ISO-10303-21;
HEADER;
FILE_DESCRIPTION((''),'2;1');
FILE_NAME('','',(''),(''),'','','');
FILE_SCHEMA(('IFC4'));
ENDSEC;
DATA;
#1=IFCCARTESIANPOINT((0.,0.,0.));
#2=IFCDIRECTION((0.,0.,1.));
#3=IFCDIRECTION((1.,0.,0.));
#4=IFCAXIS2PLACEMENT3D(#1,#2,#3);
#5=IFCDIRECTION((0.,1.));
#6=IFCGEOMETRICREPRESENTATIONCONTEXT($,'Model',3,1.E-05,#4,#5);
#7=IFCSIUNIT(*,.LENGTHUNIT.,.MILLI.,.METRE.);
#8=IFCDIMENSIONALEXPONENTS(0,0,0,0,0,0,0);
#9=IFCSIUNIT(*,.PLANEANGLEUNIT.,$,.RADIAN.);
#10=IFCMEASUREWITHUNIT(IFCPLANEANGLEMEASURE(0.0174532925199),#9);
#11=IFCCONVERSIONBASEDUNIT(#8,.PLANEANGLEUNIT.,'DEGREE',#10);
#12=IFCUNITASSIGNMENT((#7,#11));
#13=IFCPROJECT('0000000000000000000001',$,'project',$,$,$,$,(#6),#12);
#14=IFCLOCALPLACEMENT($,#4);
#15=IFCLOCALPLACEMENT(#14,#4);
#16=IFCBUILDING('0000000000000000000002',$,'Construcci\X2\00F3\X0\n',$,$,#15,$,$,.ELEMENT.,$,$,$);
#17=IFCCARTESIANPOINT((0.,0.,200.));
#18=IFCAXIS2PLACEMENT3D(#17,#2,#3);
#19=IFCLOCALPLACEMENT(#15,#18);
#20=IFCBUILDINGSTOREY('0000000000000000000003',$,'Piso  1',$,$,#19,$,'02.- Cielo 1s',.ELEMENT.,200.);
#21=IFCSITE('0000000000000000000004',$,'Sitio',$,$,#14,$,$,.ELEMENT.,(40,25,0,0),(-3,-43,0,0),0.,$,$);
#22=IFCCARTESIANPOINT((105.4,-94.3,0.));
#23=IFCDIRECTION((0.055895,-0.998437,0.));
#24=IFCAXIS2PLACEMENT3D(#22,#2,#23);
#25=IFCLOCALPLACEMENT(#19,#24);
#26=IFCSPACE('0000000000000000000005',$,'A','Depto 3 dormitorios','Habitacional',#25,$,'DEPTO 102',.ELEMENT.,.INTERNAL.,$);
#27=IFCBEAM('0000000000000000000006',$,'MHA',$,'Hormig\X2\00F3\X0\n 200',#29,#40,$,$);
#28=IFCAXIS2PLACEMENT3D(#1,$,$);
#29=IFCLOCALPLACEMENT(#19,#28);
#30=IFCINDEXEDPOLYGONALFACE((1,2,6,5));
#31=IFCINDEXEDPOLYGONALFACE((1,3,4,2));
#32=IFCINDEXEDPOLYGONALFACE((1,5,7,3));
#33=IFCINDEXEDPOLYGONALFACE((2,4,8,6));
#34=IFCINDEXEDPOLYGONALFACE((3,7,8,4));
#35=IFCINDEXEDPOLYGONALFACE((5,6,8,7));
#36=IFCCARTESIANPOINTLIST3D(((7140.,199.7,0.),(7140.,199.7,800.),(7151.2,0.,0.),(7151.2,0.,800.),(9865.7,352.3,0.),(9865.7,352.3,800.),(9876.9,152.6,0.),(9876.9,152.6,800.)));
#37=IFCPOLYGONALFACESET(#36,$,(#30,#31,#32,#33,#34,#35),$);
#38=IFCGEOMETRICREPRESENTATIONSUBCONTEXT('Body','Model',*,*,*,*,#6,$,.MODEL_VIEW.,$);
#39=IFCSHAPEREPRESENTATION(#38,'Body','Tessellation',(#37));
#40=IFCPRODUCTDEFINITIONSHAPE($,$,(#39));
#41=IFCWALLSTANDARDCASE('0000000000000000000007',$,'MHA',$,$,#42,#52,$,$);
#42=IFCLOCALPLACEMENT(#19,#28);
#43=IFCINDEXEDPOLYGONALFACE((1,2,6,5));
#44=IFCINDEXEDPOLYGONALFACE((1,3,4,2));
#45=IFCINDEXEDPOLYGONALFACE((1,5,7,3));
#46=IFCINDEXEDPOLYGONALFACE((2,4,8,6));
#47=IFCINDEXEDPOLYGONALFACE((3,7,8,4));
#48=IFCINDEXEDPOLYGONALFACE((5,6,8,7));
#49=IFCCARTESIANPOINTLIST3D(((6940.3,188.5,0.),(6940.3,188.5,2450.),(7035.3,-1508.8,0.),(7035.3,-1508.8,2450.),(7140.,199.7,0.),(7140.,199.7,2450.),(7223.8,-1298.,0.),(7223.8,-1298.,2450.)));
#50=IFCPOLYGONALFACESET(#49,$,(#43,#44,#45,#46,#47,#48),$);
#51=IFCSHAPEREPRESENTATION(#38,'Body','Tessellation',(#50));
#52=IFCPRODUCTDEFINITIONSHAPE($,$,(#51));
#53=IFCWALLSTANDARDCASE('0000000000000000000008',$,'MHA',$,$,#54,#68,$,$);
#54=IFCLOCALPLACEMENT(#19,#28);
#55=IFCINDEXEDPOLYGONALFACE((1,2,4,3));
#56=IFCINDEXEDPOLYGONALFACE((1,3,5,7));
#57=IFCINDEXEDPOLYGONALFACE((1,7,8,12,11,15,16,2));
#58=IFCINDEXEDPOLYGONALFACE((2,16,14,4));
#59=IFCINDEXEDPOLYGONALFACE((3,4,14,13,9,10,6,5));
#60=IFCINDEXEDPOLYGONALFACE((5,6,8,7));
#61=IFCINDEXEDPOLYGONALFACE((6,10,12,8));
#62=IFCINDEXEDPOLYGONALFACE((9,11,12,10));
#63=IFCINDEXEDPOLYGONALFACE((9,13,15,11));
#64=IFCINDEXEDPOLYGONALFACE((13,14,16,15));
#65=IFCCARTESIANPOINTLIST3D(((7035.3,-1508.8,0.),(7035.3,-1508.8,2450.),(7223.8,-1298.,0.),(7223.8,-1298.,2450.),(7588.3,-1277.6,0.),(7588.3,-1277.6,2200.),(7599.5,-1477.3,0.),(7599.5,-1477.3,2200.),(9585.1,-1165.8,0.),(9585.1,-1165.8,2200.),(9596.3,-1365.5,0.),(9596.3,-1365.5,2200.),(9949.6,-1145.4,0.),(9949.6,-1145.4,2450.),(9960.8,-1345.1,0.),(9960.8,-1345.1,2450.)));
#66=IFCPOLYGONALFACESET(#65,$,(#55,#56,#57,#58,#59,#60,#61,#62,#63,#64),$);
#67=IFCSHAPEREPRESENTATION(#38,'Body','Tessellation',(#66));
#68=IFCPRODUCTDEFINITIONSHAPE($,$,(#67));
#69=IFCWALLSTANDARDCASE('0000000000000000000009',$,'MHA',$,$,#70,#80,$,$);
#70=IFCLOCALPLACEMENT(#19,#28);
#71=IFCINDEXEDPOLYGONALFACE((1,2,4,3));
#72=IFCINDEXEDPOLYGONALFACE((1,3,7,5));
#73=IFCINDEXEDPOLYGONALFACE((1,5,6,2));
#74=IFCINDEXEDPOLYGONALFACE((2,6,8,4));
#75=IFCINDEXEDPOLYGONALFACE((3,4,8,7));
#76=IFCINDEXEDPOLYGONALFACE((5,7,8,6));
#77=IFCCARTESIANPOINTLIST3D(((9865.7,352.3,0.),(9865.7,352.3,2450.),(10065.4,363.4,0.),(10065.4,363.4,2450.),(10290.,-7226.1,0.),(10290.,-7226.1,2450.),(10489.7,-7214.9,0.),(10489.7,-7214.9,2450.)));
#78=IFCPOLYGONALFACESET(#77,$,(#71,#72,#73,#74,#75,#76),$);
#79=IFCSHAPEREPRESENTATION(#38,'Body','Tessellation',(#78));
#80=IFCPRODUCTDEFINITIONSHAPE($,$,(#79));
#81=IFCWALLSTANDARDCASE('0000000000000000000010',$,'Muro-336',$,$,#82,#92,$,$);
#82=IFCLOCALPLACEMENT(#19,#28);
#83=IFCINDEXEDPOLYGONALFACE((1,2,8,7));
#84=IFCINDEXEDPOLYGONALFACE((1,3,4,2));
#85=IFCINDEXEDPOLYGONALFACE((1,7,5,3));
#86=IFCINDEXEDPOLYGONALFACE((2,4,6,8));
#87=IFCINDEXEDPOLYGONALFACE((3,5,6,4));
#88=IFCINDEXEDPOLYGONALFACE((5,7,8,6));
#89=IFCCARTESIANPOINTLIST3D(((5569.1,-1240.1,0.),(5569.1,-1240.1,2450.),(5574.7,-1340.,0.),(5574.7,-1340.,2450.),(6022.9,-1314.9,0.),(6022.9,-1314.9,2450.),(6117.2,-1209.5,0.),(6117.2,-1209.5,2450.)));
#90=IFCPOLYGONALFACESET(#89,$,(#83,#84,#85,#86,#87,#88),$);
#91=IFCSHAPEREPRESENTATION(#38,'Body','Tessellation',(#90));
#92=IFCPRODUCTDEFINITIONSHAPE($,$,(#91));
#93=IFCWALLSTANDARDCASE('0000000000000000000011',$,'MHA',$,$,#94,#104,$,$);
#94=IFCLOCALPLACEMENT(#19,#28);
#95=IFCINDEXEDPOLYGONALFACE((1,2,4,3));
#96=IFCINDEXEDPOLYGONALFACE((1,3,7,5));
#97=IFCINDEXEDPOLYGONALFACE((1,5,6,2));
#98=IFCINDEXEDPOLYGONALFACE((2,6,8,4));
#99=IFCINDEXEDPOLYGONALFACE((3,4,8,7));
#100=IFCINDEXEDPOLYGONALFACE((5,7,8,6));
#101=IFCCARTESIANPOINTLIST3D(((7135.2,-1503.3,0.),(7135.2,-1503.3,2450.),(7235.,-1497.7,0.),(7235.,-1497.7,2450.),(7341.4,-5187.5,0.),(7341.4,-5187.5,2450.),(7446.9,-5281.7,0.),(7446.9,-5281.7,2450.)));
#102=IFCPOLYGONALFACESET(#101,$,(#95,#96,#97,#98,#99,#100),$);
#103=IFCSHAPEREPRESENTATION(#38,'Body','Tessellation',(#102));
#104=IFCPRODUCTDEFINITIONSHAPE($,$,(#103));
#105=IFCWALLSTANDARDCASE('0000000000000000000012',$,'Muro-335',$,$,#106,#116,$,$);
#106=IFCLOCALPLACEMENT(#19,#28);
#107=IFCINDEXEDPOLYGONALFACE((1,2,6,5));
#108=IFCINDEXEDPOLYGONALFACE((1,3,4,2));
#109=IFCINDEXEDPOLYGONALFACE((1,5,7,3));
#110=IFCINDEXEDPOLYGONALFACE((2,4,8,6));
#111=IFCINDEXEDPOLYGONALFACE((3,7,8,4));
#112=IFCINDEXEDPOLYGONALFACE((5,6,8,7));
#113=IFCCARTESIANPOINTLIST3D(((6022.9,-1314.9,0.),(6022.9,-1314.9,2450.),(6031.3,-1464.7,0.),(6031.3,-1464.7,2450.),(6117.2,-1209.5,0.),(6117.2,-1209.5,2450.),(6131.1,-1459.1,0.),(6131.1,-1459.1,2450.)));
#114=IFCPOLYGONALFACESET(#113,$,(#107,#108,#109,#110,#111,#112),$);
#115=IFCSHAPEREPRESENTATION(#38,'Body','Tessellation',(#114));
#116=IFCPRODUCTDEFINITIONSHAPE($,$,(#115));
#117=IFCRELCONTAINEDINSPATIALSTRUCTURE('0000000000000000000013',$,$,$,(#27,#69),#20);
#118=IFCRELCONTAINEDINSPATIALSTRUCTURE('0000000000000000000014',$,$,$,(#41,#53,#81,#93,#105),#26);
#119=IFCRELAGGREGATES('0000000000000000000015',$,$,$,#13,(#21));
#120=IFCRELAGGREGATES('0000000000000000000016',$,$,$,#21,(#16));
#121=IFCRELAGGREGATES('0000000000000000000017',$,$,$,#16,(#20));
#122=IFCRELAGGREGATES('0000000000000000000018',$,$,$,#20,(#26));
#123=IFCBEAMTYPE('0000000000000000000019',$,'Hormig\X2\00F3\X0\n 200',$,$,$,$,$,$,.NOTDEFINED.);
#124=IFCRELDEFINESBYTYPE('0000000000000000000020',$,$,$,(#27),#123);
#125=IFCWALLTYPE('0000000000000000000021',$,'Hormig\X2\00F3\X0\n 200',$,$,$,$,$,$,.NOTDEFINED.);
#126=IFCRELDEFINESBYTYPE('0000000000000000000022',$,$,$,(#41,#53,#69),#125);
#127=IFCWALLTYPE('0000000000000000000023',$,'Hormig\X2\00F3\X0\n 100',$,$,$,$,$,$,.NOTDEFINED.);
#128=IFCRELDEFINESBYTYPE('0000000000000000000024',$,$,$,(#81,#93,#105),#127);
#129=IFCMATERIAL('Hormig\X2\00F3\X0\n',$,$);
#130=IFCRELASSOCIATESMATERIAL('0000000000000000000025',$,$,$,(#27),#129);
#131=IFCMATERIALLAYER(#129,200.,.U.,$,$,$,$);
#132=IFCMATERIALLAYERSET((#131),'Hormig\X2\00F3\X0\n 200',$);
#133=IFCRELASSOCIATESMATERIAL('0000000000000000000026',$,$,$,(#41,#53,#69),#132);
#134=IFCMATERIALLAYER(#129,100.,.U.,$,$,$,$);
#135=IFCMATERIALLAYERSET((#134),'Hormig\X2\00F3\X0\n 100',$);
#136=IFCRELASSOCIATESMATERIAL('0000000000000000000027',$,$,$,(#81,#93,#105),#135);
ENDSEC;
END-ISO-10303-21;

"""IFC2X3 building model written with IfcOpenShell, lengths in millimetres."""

from ifc_helpers import new_model, entity, si_unit, converted_unit, direction, frame, origin_with_axes, origin_2d_with_axis, place, context, subcontext, project, spatial, polyline, rectangle, outline, extrude, material, layer, layer_set, layer_usage, type_object, element, save


model = new_model("IFC2X3")

# Units and contexts
model_context = context("Model", 3, precision=1e-05, world=origin_with_axes(), true_north=direction((0.0, 1.0)))
body_context = subcontext(model_context, "Body", "Model", "MODEL_VIEW")
ifc_project = project(units=[si_unit("LENGTHUNIT", "METRE", prefix="MILLI"), converted_unit("PLANEANGLEUNIT", "DEGREE", entity("IfcPlaneAngleMeasure", 0.0174532925199), si_unit("PLANEANGLEUNIT", "RADIAN"), dimensions=[0, 0, 0, 0, 0, 0, 0])], contexts=[model_context])

# Site, building, storey
site_placement = place(None, origin_with_axes())
site = spatial("IfcSite", under=ifc_project, at=site_placement, Name="Sitio", CompositionType="ELEMENT", RefLatitude=(40, 25, 0, 0), RefLongitude=(-3, -43, 0, 0), RefElevation=0.0)
building_placement = place(site_placement, origin_with_axes())
building = spatial("IfcBuilding", under=site, at=building_placement, Name="Construcción", CompositionType="ELEMENT")
storey_placement = place(building_placement, frame((0.0, 0.0, 200.0), z_axis=(0.0, 0.0, 1.0), x_axis=(1.0, 0.0, 0.0)))
storey = spatial("IfcBuildingStorey", under=building, at=storey_placement, Name="Piso  1", LongName="02.- Cielo 1s", CompositionType="ELEMENT", Elevation=200.0)

# Beam
ifc_material = material(Name="Hormigón")
beam_type = type_object("IfcBeamType", Name="Hormigón 200", PredefinedType="NOTDEFINED")
beam_placement = place(storey_placement, frame((7145.6, 99.8, 0.0), z_axis=(0.0, 0.0, 1.0), x_axis=(0.998437, 0.055895, 0.0)))
element("IfcBeam", 1, at=beam_placement, inside=storey, type_object=beam_type, material=ifc_material, Name="MHA", ObjectType="Hormigón 200", context=body_context, shape_type="SweptSolid", body=[
    extrude(outline(polyline([(0.0, -100.0), (2730.0, -100.0), (2730.0, 100.0), (0.0, 100.0), (0.0, -100.0)])), origin_with_axes(), (0.0, 0.0, 1.0), 800.0),
])

# Shared definitions
space_placement = place(storey_placement, frame((105.4, -94.3, 0.0), z_axis=(0.0, 0.0, 1.0), x_axis=(0.055895, -0.998437, 0.0)))
space = spatial("IfcSpace", under=storey, at=space_placement, Name="A", Description="Depto 3 dormitorios", ObjectType="Habitacional", LongName="DEPTO 102", CompositionType="ELEMENT", InteriorOrExteriorSpace="INTERNAL")

# Wall
ifc_layer_1 = layer(ifc_material, 200.0, ventilated="UNKNOWN")
ifc_layer_set_1 = layer_set([ifc_layer_1], Name="Hormigón 200")
wall_type_1 = type_object("IfcWallType", Name="Hormigón 200", PredefinedType="NOTDEFINED")
ifc_layer_usage_1 = layer_usage(ifc_layer_set_1, "AXIS2", "POSITIVE", -100.0)
wall_1_placement = place(space_placement, frame((99.7, 6940.0, 0.0), z_axis=(0.0, 0.0, 1.0), x_axis=(1.0, 0.0, 0.0)))
element("IfcWallStandardCase", 2, at=wall_1_placement, inside=space, type_object=wall_type_1, material=ifc_layer_usage_1, Name="MHA", context=body_context, shape_type="SweptSolid", body=[
    extrude(outline(polyline([(0.0, -100.0), (1700.0, -100.0), (1500.0, 100.0), (0.0, 100.0), (0.0, -100.0)])), origin_with_axes(), (0.0, 0.0, 1.0), 2450.0),
])

# Wall, opening
ifc_layer_usage_2 = layer_usage(ifc_layer_set_1, "AXIS2", "NEGATIVE", 100.0)
wall_2_placement = place(space_placement, frame((1699.7, 6940.0, 0.0), z_axis=(0.0, 0.0, 1.0), x_axis=(0.0, 1.0, 0.0)))
wall_2 = element("IfcWallStandardCase", 3, at=wall_2_placement, inside=space, type_object=wall_type_1, material=ifc_layer_usage_2, Name="MHA", context=body_context, shape_type="SweptSolid", body=[
    extrude(outline(polyline([(-100.0, -100.0), (2830.0, -100.0), (2830.0, 100.0), (100.0, 100.0), (-100.0, -100.0)])), origin_with_axes(), (0.0, 0.0, 1.0), 2450.0),
])
opening_1_placement = place(wall_2_placement, frame((1465.0, 0.0, 0.0), z_axis=(0.0, 0.0, 1.0), x_axis=(1.0, 0.0, 0.0)))
element("IfcOpeningElement", 4, at=opening_1_placement, cuts=wall_2, context=body_context, shape_type="SweptSolid", body=[
    extrude(rectangle(XDim=2000.0, YDim=2200.0, at=origin_2d_with_axis()), frame((0.0, 200.0, 1100.0), z_axis=(0.0, -1.0, 0.0), x_axis=(-1.0, 0.0, 0.0)), (0.0, 0.0, 1.0), 600.0),
])

# Walls
ifc_layer_usage_3 = layer_usage(ifc_layer_set_1, "AXIS2", "POSITIVE", -100.0)
wall_3_placement = place(storey_placement, frame((10395.4, -7320.3, 0.0), z_axis=(0.0, 0.0, 1.0), x_axis=(-0.055895, 0.998437, 0.0)))
element("IfcWallStandardCase", 5, at=wall_3_placement, inside=storey, type_object=wall_type_1, material=ifc_layer_usage_3, Name="MHA", context=body_context, shape_type="SweptSolid", body=[
    extrude(outline(polyline([(100.0, -100.0), (7690.2, -100.0), (7690.2, 100.0), (100.0, 100.0), (100.0, -100.0)])), origin_with_axes(), (0.0, 0.0, 1.0), 2450.0),
])
ifc_layer_2 = layer(ifc_material, 100.0, ventilated="UNKNOWN")
ifc_layer_set_2 = layer_set([ifc_layer_2], Name="Hormigón 100")
wall_type_2 = type_object("IfcWallType", Name="Hormigón 100", PredefinedType="NOTDEFINED")
ifc_layer_usage_4 = layer_usage(ifc_layer_set_2, "AXIS2", "POSITIVE", -100.0)
wall_4_placement = place(space_placement, frame((1549.5, 5840.0, 0.0), z_axis=(0.0, 0.0, 1.0), x_axis=(0.000005, -1.0, 0.0)))
element("IfcWallStandardCase", 6, at=wall_4_placement, inside=space, type_object=wall_type_2, material=ifc_layer_usage_4, Name="Muro-336", context=body_context, shape_type="SweptSolid", body=[
    extrude(outline(polyline([(-100.0, -100.0), (448.9, -100.0), (448.9, 0.0), (0.0, 0.0), (-100.0, -100.0)])), origin_with_axes(), (0.0, 0.0, 1.0), 2450.0),
])

# Walls
ifc_layer_usage_5 = layer_usage(ifc_layer_set_2, "AXIS2", "NEGATIVE", 50.0)
wall_5_placement = place(space_placement, frame((5589.7, 6990.0, 0.0), z_axis=(0.0, 0.0, 1.0), x_axis=(-1.0, -0.000003, 0.0)))
element("IfcWallStandardCase", 7, at=wall_5_placement, inside=space, type_object=wall_type_2, material=ifc_layer_usage_5, Name="MHA", context=body_context, shape_type="SweptSolid", body=[
    extrude(outline(polyline([(0.0, -50.0), (3790.0, -50.0), (3790.0, 50.0), (100.0, 50.0), (0.0, -50.0)])), origin_with_axes(), (0.0, 0.0, 1.0), 2450.0),
])
ifc_layer_usage_6 = layer_usage(ifc_layer_set_2, "AXIS2", "POSITIVE", -100.0)
wall_6_placement = place(space_placement, frame((1699.5, 5840.0, 0.0), z_axis=(0.0, 0.0, 1.0), x_axis=(-1.0, -0.000005, 0.0)))
element("IfcWallStandardCase", 8, at=wall_6_placement, inside=space, type_object=wall_type_2, material=ifc_layer_usage_6, Name="Muro-335", context=body_context, shape_type="SweptSolid", body=[
    extrude(outline(polyline([(0.0, -100.0), (250.0, -100.0), (150.0, 0.0), (0.0, 0.0), (0.0, -100.0)])), origin_with_axes(), (0.0, 0.0, 1.0), 2450.0),
])

save(model, "model.ifc")
